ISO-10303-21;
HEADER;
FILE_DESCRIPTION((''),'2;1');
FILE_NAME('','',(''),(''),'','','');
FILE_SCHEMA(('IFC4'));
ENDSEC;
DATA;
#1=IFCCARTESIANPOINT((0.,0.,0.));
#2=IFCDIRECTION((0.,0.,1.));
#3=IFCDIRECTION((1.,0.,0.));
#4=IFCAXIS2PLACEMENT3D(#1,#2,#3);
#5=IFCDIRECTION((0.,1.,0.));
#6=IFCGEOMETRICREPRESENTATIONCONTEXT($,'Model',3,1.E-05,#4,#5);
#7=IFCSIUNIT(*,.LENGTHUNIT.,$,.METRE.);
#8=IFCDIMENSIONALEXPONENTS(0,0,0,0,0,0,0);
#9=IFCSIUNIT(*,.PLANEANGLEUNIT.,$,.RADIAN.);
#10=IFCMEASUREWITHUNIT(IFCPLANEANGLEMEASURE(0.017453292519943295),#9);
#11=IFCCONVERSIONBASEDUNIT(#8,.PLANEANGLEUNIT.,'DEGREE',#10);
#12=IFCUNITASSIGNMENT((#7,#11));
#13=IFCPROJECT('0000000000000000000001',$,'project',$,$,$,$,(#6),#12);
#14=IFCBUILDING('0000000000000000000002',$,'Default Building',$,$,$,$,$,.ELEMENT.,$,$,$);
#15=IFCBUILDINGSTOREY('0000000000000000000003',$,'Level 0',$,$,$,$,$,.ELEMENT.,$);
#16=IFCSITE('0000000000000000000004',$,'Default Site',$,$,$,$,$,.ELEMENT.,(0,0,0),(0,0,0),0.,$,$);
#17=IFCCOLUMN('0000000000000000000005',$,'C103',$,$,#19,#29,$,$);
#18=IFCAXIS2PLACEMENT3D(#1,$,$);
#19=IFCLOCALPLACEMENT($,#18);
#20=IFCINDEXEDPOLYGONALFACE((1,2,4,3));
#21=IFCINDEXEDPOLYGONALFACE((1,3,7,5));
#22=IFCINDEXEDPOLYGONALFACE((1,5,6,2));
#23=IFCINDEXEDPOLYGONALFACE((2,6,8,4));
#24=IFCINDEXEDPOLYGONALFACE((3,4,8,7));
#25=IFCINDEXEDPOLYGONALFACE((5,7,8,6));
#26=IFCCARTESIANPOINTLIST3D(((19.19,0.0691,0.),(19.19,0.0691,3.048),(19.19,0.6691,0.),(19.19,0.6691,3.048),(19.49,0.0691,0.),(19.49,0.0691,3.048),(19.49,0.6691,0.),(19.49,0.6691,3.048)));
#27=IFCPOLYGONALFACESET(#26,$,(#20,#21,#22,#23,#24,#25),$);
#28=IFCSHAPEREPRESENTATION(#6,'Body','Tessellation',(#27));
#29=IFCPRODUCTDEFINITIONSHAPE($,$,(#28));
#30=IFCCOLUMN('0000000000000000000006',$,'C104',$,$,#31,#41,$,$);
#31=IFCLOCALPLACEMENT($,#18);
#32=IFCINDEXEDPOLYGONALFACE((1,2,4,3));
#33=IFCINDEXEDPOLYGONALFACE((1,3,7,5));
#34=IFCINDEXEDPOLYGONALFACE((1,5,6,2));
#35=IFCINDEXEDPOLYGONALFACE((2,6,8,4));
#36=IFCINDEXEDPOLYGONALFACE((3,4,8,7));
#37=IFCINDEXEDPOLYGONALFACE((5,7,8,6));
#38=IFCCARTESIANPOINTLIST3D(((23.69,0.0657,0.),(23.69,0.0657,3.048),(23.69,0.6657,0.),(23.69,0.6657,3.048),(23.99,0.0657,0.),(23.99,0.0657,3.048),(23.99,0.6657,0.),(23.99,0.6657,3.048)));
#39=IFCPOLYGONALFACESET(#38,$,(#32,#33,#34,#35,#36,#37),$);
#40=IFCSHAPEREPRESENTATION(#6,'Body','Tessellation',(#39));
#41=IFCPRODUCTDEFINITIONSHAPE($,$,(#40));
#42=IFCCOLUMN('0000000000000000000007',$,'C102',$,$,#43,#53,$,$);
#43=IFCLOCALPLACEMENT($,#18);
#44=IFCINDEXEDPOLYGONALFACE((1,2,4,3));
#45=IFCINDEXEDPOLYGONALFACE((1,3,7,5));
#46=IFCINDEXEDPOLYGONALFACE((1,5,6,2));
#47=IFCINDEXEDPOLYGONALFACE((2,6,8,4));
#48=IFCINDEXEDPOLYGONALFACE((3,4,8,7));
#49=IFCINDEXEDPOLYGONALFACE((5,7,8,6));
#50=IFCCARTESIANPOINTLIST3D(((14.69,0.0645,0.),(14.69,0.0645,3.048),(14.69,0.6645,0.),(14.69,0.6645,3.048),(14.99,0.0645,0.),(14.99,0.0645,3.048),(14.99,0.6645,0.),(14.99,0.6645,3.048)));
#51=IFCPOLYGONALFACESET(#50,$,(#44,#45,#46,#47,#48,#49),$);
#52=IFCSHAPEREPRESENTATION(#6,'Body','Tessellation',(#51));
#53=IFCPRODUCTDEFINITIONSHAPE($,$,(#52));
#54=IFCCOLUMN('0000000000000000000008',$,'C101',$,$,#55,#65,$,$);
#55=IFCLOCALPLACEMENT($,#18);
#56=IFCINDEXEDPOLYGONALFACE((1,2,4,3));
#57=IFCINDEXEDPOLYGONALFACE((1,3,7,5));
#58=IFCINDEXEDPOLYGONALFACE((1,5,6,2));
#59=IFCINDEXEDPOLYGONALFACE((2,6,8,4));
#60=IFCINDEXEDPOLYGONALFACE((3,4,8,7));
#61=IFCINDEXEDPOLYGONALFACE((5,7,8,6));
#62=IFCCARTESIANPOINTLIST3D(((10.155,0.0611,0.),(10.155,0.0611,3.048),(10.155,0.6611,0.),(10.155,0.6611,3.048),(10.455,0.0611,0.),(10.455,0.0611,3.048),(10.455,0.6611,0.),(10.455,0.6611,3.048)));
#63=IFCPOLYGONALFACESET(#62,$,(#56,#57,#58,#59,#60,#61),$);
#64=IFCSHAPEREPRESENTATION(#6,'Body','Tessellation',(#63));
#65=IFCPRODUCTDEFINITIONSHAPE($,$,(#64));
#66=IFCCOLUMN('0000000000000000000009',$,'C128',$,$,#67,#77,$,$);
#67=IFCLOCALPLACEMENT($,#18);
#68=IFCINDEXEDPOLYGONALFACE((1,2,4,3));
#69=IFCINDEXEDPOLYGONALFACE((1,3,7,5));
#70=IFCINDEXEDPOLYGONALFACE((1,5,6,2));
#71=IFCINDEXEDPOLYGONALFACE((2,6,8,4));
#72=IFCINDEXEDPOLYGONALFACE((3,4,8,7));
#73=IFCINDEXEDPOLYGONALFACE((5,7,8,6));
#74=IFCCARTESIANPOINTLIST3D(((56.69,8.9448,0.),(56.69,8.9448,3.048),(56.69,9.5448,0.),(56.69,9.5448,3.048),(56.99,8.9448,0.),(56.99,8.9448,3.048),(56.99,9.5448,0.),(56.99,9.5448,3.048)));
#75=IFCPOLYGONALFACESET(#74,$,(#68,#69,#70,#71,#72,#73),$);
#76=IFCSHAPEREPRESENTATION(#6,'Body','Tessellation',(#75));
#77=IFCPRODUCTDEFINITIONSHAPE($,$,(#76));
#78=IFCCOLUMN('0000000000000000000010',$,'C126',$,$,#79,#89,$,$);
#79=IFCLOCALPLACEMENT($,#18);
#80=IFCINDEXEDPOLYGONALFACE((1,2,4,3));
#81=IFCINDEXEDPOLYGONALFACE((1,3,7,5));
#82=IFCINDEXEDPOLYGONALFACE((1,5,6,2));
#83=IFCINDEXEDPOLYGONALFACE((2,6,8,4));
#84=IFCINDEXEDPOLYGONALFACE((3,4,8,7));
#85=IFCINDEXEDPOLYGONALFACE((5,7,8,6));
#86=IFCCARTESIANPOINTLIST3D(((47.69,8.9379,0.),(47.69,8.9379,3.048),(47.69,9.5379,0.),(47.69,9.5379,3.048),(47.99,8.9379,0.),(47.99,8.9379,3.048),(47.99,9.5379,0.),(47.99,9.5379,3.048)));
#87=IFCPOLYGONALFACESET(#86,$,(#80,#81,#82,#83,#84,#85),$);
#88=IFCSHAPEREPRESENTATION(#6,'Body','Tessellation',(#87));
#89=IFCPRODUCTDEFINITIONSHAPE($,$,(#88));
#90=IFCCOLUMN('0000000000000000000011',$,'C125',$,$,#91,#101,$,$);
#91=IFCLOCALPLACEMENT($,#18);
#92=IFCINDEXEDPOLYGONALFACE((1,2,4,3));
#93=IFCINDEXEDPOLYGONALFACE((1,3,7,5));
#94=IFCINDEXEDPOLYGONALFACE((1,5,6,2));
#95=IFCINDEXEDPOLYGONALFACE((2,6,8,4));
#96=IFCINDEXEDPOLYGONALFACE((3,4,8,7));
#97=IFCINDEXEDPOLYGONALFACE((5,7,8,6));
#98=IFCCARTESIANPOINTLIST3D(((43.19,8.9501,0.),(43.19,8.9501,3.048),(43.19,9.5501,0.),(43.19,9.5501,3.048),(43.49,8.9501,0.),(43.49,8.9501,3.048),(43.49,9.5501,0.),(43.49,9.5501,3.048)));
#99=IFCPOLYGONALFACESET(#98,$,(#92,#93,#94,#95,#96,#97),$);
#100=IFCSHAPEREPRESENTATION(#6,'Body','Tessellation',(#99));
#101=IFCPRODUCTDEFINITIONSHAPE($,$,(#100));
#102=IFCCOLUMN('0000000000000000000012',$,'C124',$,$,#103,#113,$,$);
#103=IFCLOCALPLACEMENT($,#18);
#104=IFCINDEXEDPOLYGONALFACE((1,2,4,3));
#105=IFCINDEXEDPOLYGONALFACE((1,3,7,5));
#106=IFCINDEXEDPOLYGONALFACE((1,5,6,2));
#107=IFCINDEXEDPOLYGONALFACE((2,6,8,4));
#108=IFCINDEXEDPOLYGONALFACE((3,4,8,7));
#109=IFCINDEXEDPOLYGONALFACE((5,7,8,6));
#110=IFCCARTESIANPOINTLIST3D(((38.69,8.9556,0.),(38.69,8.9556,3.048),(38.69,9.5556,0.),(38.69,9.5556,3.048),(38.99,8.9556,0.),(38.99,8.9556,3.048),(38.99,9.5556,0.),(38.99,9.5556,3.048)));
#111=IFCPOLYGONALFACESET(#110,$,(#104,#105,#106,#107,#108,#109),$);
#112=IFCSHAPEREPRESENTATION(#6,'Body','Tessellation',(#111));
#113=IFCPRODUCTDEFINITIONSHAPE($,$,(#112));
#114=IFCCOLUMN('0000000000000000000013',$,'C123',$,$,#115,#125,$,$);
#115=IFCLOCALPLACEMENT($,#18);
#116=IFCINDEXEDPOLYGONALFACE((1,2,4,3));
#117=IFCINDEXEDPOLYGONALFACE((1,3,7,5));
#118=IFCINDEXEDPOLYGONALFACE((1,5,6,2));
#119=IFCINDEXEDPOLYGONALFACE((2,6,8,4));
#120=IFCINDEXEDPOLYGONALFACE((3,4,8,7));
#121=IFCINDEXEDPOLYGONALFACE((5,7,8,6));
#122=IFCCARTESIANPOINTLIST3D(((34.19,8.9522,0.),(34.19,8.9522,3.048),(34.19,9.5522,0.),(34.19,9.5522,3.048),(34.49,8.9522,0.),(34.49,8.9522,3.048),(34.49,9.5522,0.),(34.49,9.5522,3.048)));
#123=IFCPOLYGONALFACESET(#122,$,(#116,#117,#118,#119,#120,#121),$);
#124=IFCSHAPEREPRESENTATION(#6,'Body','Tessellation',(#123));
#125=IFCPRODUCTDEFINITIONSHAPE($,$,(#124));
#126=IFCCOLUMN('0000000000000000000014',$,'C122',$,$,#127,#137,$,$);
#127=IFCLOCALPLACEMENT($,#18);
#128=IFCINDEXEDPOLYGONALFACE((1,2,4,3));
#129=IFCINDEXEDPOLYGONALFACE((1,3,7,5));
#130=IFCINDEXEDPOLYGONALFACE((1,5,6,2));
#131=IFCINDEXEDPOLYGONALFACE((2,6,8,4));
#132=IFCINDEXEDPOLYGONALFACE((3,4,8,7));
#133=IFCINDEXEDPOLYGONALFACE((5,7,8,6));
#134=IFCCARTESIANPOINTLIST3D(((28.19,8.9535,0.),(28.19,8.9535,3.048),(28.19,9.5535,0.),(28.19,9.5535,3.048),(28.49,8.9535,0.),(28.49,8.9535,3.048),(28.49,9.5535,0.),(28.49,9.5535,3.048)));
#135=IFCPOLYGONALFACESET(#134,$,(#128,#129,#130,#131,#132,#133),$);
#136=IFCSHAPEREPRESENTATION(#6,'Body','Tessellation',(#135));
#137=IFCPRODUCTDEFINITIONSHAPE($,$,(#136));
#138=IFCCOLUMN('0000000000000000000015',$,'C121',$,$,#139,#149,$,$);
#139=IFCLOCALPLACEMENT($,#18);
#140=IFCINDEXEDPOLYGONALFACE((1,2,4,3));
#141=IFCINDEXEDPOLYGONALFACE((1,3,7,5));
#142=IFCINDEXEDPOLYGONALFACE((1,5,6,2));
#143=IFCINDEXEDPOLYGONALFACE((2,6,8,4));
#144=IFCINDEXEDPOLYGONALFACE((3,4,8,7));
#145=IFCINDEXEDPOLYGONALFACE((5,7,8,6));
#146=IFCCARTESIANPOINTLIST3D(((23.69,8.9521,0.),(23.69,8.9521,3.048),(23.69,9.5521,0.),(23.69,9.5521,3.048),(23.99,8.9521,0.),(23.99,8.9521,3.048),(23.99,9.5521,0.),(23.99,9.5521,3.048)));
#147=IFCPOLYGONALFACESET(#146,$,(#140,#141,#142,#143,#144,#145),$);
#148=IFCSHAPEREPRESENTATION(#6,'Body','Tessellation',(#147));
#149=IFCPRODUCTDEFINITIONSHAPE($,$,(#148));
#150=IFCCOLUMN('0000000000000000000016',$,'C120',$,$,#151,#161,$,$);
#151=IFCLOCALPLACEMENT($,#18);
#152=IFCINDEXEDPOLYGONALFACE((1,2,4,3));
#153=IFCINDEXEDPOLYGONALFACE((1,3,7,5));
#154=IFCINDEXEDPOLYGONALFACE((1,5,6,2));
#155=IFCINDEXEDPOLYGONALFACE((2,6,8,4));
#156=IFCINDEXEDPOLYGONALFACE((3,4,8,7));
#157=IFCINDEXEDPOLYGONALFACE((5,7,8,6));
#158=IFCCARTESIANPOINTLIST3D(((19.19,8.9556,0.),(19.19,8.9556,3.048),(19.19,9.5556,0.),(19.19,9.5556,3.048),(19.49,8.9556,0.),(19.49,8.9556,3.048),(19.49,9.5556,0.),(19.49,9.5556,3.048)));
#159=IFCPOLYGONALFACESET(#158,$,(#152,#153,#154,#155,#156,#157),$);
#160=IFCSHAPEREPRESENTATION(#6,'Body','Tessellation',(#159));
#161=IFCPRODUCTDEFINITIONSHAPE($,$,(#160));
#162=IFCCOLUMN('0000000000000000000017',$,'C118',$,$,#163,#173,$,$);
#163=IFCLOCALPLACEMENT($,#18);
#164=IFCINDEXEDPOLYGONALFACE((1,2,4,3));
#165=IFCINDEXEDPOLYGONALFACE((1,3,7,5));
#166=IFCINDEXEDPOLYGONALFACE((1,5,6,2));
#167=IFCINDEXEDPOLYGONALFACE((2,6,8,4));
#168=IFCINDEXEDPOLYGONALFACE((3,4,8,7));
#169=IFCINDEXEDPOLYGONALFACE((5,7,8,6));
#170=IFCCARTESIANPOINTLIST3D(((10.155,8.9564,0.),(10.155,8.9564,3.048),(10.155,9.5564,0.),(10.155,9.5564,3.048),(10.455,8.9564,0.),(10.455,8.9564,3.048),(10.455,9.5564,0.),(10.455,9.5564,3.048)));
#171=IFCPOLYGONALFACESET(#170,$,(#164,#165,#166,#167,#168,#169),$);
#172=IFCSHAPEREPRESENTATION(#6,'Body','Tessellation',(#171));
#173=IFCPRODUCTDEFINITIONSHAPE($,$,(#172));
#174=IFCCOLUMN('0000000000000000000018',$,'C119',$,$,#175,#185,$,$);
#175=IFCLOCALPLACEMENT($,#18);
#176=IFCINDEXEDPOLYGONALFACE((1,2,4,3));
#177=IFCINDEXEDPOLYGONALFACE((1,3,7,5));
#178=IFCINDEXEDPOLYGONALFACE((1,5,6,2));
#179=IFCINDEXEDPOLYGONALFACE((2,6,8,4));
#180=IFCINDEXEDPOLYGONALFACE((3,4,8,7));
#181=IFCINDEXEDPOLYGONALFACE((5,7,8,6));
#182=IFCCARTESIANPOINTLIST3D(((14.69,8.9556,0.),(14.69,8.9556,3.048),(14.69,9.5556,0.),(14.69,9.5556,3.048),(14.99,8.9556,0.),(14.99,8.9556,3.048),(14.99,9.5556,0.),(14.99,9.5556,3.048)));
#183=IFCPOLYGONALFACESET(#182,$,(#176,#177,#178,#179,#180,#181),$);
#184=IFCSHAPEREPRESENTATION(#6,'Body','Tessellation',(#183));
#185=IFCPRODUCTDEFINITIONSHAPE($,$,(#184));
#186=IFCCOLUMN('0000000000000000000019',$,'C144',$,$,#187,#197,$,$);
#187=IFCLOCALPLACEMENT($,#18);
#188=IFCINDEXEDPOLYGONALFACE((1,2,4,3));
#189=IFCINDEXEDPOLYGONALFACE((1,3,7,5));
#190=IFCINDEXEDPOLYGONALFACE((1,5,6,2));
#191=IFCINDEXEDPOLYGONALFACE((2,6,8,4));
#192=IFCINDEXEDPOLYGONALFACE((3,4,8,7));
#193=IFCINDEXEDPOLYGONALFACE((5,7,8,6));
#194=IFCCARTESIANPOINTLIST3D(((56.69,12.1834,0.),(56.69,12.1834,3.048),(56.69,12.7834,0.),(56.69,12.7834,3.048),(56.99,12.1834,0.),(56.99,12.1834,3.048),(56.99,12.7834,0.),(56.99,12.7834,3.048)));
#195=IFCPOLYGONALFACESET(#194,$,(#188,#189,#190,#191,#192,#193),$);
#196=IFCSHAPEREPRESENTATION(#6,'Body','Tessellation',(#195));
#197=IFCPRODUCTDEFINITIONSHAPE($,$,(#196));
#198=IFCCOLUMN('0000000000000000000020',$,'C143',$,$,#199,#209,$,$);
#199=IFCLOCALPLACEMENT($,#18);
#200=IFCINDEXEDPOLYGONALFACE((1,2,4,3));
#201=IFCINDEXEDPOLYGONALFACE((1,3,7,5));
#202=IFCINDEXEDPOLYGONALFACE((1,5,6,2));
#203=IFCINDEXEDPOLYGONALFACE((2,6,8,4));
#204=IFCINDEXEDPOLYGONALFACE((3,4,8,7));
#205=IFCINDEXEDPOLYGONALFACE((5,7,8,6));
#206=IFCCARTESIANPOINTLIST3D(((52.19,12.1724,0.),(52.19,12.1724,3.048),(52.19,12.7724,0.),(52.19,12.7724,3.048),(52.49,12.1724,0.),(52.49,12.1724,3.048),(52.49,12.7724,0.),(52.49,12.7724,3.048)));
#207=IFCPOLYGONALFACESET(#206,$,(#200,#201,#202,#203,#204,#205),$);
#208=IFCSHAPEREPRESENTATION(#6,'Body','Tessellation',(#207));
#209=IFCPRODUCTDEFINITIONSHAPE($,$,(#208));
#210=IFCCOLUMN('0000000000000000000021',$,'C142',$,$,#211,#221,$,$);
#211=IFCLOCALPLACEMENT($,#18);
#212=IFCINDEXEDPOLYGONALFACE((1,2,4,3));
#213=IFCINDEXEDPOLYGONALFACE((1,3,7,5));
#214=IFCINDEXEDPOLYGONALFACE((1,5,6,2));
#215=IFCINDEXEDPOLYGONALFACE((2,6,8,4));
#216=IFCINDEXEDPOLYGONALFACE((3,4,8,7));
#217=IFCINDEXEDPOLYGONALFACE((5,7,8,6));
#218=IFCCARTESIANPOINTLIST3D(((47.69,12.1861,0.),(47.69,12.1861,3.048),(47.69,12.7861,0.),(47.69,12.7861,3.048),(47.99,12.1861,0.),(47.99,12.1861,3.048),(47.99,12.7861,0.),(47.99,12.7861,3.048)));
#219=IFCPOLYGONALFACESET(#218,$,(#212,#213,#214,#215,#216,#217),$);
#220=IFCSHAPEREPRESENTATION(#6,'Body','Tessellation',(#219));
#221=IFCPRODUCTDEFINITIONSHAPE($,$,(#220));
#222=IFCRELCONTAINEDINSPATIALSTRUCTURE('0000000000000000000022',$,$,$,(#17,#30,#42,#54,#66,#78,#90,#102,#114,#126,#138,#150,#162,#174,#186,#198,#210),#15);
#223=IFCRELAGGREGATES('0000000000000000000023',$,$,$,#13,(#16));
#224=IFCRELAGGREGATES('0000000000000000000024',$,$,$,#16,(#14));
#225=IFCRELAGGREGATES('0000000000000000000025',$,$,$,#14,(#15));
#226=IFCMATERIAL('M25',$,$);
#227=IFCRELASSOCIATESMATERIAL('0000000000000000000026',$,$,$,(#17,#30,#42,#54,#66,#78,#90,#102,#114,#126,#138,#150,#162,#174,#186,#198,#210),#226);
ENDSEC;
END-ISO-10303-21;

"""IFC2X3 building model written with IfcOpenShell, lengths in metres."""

from ifc_helpers import new_model, entity, si_unit, converted_unit, direction, frame, frame_2d, origin_with_axes, place, context, project, spatial, rectangle, extrude, material, element, save


model = new_model("IFC2X3")

# Units and contexts
model_context = context("Model", 3, precision=1e-05, world=origin_with_axes(), true_north=direction((0.0, 1.0, 0.0)))
ifc_project = project(units=[si_unit("LENGTHUNIT", "METRE"), converted_unit("PLANEANGLEUNIT", "DEGREE", entity("IfcPlaneAngleMeasure", 0.017453292519943295), si_unit("PLANEANGLEUNIT", "RADIAN"), dimensions=[0, 0, 0, 0, 0, 0, 0])], contexts=[model_context])

# Site, building, storey
site = spatial("IfcSite", under=ifc_project, Name="Default Site", CompositionType="ELEMENT", RefLatitude=(0, 0, 0), RefLongitude=(0, 0, 0), RefElevation=0.0)
building = spatial("IfcBuilding", under=site, Name="Default Building", CompositionType="ELEMENT")
storey = spatial("IfcBuildingStorey", under=building, Name="Level 0", CompositionType="ELEMENT")

# Columns
ifc_material = material(Name="M25")
placement = place(None, origin_with_axes())
element("IfcColumn", 1, at=placement, inside=storey, material=ifc_material, Name="C103", context=model_context, shape_type="SweptSolid", body=[
    extrude(rectangle(XDim=0.3, YDim=0.6, at=frame_2d((0.0, 0.0), x_axis=(1.0, 0.0, 0.0))), frame((19.34, 0.3691, 0.0), z_axis=(0.0, 0.0, 1.0), x_axis=(1.0, 0.0, 0.0)), (0.0, 0.0, 1.0), 3.048),
])
element("IfcColumn", 2, at=placement, inside=storey, material=ifc_material, Name="C104", context=model_context, shape_type="SweptSolid", body=[
    extrude(rectangle(XDim=0.3, YDim=0.6, at=frame_2d((0.0, 0.0), x_axis=(1.0, 0.0, 0.0))), frame((23.84, 0.3657, 0.0), z_axis=(0.0, 0.0, 1.0), x_axis=(1.0, 0.0, 0.0)), (0.0, 0.0, 1.0), 3.048),
])
element("IfcColumn", 3, at=placement, inside=storey, material=ifc_material, Name="C102", context=model_context, shape_type="SweptSolid", body=[
    extrude(rectangle(XDim=0.3, YDim=0.6, at=frame_2d((0.0, 0.0), x_axis=(1.0, 0.0, 0.0))), frame((14.84, 0.3645, 0.0), z_axis=(0.0, 0.0, 1.0), x_axis=(1.0, 0.0, 0.0)), (0.0, 0.0, 1.0), 3.048),
])
element("IfcColumn", 4, at=placement, inside=storey, material=ifc_material, Name="C101", context=model_context, shape_type="SweptSolid", body=[
    extrude(rectangle(XDim=0.3, YDim=0.6, at=frame_2d((0.0, 0.0), x_axis=(1.0, 0.0, 0.0))), frame((10.305, 0.3611, 0.0), z_axis=(0.0, 0.0, 1.0), x_axis=(1.0, 0.0, 0.0)), (0.0, 0.0, 1.0), 3.048),
])
element("IfcColumn", 5, at=placement, inside=storey, material=ifc_material, Name="C128", context=model_context, shape_type="SweptSolid", body=[
    extrude(rectangle(XDim=0.3, YDim=0.6, at=frame_2d((0.0, 0.0), x_axis=(1.0, 0.0, 0.0))), frame((56.84, 9.2448, 0.0), z_axis=(0.0, 0.0, 1.0), x_axis=(1.0, 0.0, 0.0)), (0.0, 0.0, 1.0), 3.048),
])
element("IfcColumn", 6, at=placement, inside=storey, material=ifc_material, Name="C126", context=model_context, shape_type="SweptSolid", body=[
    extrude(rectangle(XDim=0.3, YDim=0.6, at=frame_2d((0.0, 0.0), x_axis=(1.0, 0.0, 0.0))), frame((47.84, 9.2379, 0.0), z_axis=(0.0, 0.0, 1.0), x_axis=(1.0, 0.0, 0.0)), (0.0, 0.0, 1.0), 3.048),
])
element("IfcColumn", 7, at=placement, inside=storey, material=ifc_material, Name="C125", context=model_context, shape_type="SweptSolid", body=[
    extrude(rectangle(XDim=0.3, YDim=0.6, at=frame_2d((0.0, 0.0), x_axis=(1.0, 0.0, 0.0))), frame((43.34, 9.2501, 0.0), z_axis=(0.0, 0.0, 1.0), x_axis=(1.0, 0.0, 0.0)), (0.0, 0.0, 1.0), 3.048),
])
element("IfcColumn", 8, at=placement, inside=storey, material=ifc_material, Name="C124", context=model_context, shape_type="SweptSolid", body=[
    extrude(rectangle(XDim=0.3, YDim=0.6, at=frame_2d((0.0, 0.0), x_axis=(1.0, 0.0, 0.0))), frame((38.84, 9.2556, 0.0), z_axis=(0.0, 0.0, 1.0), x_axis=(1.0, 0.0, 0.0)), (0.0, 0.0, 1.0), 3.048),
])
element("IfcColumn", 9, at=placement, inside=storey, material=ifc_material, Name="C123", context=model_context, shape_type="SweptSolid", body=[
    extrude(rectangle(XDim=0.3, YDim=0.6, at=frame_2d((0.0, 0.0), x_axis=(1.0, 0.0, 0.0))), frame((34.34, 9.2522, 0.0), z_axis=(0.0, 0.0, 1.0), x_axis=(1.0, 0.0, 0.0)), (0.0, 0.0, 1.0), 3.048),
])
element("IfcColumn", 10, at=placement, inside=storey, material=ifc_material, Name="C122", context=model_context, shape_type="SweptSolid", body=[
    extrude(rectangle(XDim=0.3, YDim=0.6, at=frame_2d((0.0, 0.0), x_axis=(1.0, 0.0, 0.0))), frame((28.34, 9.2535, 0.0), z_axis=(0.0, 0.0, 1.0), x_axis=(1.0, 0.0, 0.0)), (0.0, 0.0, 1.0), 3.048),
])
element("IfcColumn", 11, at=placement, inside=storey, material=ifc_material, Name="C121", context=model_context, shape_type="SweptSolid", body=[
    extrude(rectangle(XDim=0.3, YDim=0.6, at=frame_2d((0.0, 0.0), x_axis=(1.0, 0.0, 0.0))), frame((23.84, 9.2521, 0.0), z_axis=(0.0, 0.0, 1.0), x_axis=(1.0, 0.0, 0.0)), (0.0, 0.0, 1.0), 3.048),
])
element("IfcColumn", 12, at=placement, inside=storey, material=ifc_material, Name="C120", context=model_context, shape_type="SweptSolid", body=[
    extrude(rectangle(XDim=0.3, YDim=0.6, at=frame_2d((0.0, 0.0), x_axis=(1.0, 0.0, 0.0))), frame((19.34, 9.2556, 0.0), z_axis=(0.0, 0.0, 1.0), x_axis=(1.0, 0.0, 0.0)), (0.0, 0.0, 1.0), 3.048),
])
element("IfcColumn", 13, at=placement, inside=storey, material=ifc_material, Name="C118", context=model_context, shape_type="SweptSolid", body=[
    extrude(rectangle(XDim=0.3, YDim=0.6, at=frame_2d((0.0, 0.0), x_axis=(1.0, 0.0, 0.0))), frame((10.305, 9.2564, 0.0), z_axis=(0.0, 0.0, 1.0), x_axis=(1.0, 0.0, 0.0)), (0.0, 0.0, 1.0), 3.048),
])
element("IfcColumn", 14, at=placement, inside=storey, material=ifc_material, Name="C119", context=model_context, shape_type="SweptSolid", body=[
    extrude(rectangle(XDim=0.3, YDim=0.6, at=frame_2d((0.0, 0.0), x_axis=(1.0, 0.0, 0.0))), frame((14.84, 9.2556, 0.0), z_axis=(0.0, 0.0, 1.0), x_axis=(1.0, 0.0, 0.0)), (0.0, 0.0, 1.0), 3.048),
])
element("IfcColumn", 15, at=placement, inside=storey, material=ifc_material, Name="C144", context=model_context, shape_type="SweptSolid", body=[
    extrude(rectangle(XDim=0.3, YDim=0.6, at=frame_2d((0.0, 0.0), x_axis=(1.0, 0.0, 0.0))), frame((56.84, 12.4834, 0.0), z_axis=(0.0, 0.0, 1.0), x_axis=(1.0, 0.0, 0.0)), (0.0, 0.0, 1.0), 3.048),
])
element("IfcColumn", 16, at=placement, inside=storey, material=ifc_material, Name="C143", context=model_context, shape_type="SweptSolid", body=[
    extrude(rectangle(XDim=0.3, YDim=0.6, at=frame_2d((0.0, 0.0), x_axis=(1.0, 0.0, 0.0))), frame((52.34, 12.4724, 0.0), z_axis=(0.0, 0.0, 1.0), x_axis=(1.0, 0.0, 0.0)), (0.0, 0.0, 1.0), 3.048),
])
element("IfcColumn", 17, at=placement, inside=storey, material=ifc_material, Name="C142", context=model_context, shape_type="SweptSolid", body=[
    extrude(rectangle(XDim=0.3, YDim=0.6, at=frame_2d((0.0, 0.0), x_axis=(1.0, 0.0, 0.0))), frame((47.84, 12.4861, 0.0), z_axis=(0.0, 0.0, 1.0), x_axis=(1.0, 0.0, 0.0)), (0.0, 0.0, 1.0), 3.048),
])

save(model, "model.ifc")
